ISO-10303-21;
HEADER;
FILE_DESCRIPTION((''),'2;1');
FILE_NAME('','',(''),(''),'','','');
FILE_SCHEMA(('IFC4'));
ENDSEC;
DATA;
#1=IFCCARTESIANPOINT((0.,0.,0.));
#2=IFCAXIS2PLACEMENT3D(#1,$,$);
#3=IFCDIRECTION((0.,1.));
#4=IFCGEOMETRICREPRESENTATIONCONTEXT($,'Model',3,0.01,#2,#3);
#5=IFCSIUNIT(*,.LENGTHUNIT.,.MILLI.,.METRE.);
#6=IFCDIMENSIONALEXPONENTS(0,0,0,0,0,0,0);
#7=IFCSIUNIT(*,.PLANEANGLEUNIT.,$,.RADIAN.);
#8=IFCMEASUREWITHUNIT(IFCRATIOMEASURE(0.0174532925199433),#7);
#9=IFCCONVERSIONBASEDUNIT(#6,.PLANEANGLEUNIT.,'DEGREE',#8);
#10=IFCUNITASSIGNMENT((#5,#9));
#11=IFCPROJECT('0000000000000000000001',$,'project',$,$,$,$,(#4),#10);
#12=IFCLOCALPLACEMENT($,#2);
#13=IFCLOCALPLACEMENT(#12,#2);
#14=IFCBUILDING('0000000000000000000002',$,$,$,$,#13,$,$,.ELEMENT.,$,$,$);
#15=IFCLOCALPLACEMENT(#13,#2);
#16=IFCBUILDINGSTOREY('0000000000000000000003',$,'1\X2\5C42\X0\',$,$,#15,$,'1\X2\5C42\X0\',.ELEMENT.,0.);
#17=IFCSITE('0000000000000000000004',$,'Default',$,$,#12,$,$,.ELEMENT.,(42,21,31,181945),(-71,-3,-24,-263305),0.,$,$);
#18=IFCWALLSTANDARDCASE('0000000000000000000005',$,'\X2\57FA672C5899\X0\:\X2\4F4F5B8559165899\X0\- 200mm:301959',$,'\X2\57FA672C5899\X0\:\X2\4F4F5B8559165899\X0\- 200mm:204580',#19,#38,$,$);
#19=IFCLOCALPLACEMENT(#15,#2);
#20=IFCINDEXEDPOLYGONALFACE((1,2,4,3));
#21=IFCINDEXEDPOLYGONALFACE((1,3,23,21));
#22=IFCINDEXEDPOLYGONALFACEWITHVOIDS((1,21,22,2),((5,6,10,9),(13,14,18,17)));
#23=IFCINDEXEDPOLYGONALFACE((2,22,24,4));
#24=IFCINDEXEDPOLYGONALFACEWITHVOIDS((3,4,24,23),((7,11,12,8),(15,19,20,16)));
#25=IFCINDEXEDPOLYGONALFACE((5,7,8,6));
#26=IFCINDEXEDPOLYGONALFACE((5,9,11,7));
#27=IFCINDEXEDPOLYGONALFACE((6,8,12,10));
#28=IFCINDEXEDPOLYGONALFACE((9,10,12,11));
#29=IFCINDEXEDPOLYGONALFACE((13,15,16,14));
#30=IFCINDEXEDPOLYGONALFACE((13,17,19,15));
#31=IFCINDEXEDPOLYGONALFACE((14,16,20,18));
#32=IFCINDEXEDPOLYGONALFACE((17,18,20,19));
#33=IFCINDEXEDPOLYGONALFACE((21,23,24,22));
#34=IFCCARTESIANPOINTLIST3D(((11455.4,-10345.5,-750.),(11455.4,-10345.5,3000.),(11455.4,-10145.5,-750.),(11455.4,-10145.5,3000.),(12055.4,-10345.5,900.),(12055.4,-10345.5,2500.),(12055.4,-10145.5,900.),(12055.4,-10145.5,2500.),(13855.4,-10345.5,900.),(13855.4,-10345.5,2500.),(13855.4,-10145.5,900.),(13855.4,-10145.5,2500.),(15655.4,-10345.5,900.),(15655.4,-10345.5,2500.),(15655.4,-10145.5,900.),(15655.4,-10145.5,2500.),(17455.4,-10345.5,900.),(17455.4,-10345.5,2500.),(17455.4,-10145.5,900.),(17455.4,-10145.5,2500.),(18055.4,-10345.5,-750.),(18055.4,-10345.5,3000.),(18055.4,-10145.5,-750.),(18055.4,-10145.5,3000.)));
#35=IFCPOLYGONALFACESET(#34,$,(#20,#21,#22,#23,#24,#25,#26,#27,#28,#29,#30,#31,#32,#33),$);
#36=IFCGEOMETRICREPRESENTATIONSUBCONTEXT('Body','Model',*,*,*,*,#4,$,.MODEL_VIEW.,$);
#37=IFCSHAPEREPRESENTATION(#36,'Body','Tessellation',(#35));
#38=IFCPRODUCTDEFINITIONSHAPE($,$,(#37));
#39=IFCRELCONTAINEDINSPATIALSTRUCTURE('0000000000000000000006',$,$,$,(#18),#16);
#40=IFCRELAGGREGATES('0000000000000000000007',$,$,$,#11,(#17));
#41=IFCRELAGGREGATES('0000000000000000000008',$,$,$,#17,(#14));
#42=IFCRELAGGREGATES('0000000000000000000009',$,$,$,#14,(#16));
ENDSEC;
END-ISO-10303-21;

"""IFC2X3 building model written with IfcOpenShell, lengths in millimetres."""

from ifc_helpers import new_model, entity, si_unit, converted_unit, direction, frame, frame_2d, origin, place, context, subcontext, project, spatial, rectangle, extrude, element, save


model = new_model("IFC2X3")

# Units and contexts
model_context = context("Model", 3, precision=0.01, world=origin(), true_north=direction((0.0, 1.0)))
body_context = subcontext(model_context, "Body", "Model", "MODEL_VIEW")
ifc_project = project(units=[si_unit("LENGTHUNIT", "METRE", prefix="MILLI"), converted_unit("PLANEANGLEUNIT", "DEGREE", entity("IfcRatioMeasure", 0.0174532925199433), si_unit("PLANEANGLEUNIT", "RADIAN"), dimensions=[0, 0, 0, 0, 0, 0, 0])], contexts=[model_context])

# Site, building, storey
site_placement = place(None, origin())
site = spatial("IfcSite", under=ifc_project, at=site_placement, Name="Default", CompositionType="ELEMENT", RefLatitude=(42, 21, 31, 181945), RefLongitude=(-71, -3, -24, -263305), RefElevation=0.0)
building_placement = place(site_placement, origin())
building = spatial("IfcBuilding", under=site, at=building_placement, CompositionType="ELEMENT")
storey_placement = place(building_placement, origin())
storey = spatial("IfcBuildingStorey", under=building, at=storey_placement, Name="1层", LongName="1层", CompositionType="ELEMENT", Elevation=0.0)

# Wall, openings
wall_placement = place(storey_placement, frame((11455.4, -10245.5, -750.0)))
wall = element("IfcWallStandardCase", 1, at=wall_placement, inside=storey, Name="基本墙:住宅外墙- 200mm:301959", ObjectType="基本墙:住宅外墙- 200mm:204580", context=body_context, shape_type="SweptSolid", body=[
    extrude(rectangle(XDim=6600.0, YDim=200.0, at=frame_2d((3300.0, 0.0), x_axis=(-1.0, 0.0))), origin(), (0.0, 0.0, 1.0), 3750.0),
])
opening_1_placement = place(wall_placement, frame((600.0, -100.0, 1650.0)))
element("IfcOpeningElement", 2, at=opening_1_placement, cuts=wall, ObjectType="Opening", context=body_context, shape_type="SweptSolid", body=[
    extrude(rectangle(XDim=1600.0, YDim=1800.0, at=frame_2d((800.0, 900.0), x_axis=(1.0, 0.0))), frame((0.0, 0.0, 0.0), z_axis=(0.0, 1.0, 0.0), x_axis=(0.0, 0.0, 1.0)), (0.0, 0.0, 1.0), 200.0),
])
opening_2_placement = place(wall_placement, frame((4200.0, -100.0, 1650.0)))
element("IfcOpeningElement", 3, at=opening_2_placement, cuts=wall, ObjectType="Opening", context=body_context, shape_type="SweptSolid", body=[
    extrude(rectangle(XDim=1600.0, YDim=1800.0, at=frame_2d((800.0, 900.0), x_axis=(1.0, 0.0))), frame((0.0, 0.0, 0.0), z_axis=(0.0, 1.0, 0.0), x_axis=(0.0, 0.0, 1.0)), (0.0, 0.0, 1.0), 200.0),
])

save(model, "model.ifc")
